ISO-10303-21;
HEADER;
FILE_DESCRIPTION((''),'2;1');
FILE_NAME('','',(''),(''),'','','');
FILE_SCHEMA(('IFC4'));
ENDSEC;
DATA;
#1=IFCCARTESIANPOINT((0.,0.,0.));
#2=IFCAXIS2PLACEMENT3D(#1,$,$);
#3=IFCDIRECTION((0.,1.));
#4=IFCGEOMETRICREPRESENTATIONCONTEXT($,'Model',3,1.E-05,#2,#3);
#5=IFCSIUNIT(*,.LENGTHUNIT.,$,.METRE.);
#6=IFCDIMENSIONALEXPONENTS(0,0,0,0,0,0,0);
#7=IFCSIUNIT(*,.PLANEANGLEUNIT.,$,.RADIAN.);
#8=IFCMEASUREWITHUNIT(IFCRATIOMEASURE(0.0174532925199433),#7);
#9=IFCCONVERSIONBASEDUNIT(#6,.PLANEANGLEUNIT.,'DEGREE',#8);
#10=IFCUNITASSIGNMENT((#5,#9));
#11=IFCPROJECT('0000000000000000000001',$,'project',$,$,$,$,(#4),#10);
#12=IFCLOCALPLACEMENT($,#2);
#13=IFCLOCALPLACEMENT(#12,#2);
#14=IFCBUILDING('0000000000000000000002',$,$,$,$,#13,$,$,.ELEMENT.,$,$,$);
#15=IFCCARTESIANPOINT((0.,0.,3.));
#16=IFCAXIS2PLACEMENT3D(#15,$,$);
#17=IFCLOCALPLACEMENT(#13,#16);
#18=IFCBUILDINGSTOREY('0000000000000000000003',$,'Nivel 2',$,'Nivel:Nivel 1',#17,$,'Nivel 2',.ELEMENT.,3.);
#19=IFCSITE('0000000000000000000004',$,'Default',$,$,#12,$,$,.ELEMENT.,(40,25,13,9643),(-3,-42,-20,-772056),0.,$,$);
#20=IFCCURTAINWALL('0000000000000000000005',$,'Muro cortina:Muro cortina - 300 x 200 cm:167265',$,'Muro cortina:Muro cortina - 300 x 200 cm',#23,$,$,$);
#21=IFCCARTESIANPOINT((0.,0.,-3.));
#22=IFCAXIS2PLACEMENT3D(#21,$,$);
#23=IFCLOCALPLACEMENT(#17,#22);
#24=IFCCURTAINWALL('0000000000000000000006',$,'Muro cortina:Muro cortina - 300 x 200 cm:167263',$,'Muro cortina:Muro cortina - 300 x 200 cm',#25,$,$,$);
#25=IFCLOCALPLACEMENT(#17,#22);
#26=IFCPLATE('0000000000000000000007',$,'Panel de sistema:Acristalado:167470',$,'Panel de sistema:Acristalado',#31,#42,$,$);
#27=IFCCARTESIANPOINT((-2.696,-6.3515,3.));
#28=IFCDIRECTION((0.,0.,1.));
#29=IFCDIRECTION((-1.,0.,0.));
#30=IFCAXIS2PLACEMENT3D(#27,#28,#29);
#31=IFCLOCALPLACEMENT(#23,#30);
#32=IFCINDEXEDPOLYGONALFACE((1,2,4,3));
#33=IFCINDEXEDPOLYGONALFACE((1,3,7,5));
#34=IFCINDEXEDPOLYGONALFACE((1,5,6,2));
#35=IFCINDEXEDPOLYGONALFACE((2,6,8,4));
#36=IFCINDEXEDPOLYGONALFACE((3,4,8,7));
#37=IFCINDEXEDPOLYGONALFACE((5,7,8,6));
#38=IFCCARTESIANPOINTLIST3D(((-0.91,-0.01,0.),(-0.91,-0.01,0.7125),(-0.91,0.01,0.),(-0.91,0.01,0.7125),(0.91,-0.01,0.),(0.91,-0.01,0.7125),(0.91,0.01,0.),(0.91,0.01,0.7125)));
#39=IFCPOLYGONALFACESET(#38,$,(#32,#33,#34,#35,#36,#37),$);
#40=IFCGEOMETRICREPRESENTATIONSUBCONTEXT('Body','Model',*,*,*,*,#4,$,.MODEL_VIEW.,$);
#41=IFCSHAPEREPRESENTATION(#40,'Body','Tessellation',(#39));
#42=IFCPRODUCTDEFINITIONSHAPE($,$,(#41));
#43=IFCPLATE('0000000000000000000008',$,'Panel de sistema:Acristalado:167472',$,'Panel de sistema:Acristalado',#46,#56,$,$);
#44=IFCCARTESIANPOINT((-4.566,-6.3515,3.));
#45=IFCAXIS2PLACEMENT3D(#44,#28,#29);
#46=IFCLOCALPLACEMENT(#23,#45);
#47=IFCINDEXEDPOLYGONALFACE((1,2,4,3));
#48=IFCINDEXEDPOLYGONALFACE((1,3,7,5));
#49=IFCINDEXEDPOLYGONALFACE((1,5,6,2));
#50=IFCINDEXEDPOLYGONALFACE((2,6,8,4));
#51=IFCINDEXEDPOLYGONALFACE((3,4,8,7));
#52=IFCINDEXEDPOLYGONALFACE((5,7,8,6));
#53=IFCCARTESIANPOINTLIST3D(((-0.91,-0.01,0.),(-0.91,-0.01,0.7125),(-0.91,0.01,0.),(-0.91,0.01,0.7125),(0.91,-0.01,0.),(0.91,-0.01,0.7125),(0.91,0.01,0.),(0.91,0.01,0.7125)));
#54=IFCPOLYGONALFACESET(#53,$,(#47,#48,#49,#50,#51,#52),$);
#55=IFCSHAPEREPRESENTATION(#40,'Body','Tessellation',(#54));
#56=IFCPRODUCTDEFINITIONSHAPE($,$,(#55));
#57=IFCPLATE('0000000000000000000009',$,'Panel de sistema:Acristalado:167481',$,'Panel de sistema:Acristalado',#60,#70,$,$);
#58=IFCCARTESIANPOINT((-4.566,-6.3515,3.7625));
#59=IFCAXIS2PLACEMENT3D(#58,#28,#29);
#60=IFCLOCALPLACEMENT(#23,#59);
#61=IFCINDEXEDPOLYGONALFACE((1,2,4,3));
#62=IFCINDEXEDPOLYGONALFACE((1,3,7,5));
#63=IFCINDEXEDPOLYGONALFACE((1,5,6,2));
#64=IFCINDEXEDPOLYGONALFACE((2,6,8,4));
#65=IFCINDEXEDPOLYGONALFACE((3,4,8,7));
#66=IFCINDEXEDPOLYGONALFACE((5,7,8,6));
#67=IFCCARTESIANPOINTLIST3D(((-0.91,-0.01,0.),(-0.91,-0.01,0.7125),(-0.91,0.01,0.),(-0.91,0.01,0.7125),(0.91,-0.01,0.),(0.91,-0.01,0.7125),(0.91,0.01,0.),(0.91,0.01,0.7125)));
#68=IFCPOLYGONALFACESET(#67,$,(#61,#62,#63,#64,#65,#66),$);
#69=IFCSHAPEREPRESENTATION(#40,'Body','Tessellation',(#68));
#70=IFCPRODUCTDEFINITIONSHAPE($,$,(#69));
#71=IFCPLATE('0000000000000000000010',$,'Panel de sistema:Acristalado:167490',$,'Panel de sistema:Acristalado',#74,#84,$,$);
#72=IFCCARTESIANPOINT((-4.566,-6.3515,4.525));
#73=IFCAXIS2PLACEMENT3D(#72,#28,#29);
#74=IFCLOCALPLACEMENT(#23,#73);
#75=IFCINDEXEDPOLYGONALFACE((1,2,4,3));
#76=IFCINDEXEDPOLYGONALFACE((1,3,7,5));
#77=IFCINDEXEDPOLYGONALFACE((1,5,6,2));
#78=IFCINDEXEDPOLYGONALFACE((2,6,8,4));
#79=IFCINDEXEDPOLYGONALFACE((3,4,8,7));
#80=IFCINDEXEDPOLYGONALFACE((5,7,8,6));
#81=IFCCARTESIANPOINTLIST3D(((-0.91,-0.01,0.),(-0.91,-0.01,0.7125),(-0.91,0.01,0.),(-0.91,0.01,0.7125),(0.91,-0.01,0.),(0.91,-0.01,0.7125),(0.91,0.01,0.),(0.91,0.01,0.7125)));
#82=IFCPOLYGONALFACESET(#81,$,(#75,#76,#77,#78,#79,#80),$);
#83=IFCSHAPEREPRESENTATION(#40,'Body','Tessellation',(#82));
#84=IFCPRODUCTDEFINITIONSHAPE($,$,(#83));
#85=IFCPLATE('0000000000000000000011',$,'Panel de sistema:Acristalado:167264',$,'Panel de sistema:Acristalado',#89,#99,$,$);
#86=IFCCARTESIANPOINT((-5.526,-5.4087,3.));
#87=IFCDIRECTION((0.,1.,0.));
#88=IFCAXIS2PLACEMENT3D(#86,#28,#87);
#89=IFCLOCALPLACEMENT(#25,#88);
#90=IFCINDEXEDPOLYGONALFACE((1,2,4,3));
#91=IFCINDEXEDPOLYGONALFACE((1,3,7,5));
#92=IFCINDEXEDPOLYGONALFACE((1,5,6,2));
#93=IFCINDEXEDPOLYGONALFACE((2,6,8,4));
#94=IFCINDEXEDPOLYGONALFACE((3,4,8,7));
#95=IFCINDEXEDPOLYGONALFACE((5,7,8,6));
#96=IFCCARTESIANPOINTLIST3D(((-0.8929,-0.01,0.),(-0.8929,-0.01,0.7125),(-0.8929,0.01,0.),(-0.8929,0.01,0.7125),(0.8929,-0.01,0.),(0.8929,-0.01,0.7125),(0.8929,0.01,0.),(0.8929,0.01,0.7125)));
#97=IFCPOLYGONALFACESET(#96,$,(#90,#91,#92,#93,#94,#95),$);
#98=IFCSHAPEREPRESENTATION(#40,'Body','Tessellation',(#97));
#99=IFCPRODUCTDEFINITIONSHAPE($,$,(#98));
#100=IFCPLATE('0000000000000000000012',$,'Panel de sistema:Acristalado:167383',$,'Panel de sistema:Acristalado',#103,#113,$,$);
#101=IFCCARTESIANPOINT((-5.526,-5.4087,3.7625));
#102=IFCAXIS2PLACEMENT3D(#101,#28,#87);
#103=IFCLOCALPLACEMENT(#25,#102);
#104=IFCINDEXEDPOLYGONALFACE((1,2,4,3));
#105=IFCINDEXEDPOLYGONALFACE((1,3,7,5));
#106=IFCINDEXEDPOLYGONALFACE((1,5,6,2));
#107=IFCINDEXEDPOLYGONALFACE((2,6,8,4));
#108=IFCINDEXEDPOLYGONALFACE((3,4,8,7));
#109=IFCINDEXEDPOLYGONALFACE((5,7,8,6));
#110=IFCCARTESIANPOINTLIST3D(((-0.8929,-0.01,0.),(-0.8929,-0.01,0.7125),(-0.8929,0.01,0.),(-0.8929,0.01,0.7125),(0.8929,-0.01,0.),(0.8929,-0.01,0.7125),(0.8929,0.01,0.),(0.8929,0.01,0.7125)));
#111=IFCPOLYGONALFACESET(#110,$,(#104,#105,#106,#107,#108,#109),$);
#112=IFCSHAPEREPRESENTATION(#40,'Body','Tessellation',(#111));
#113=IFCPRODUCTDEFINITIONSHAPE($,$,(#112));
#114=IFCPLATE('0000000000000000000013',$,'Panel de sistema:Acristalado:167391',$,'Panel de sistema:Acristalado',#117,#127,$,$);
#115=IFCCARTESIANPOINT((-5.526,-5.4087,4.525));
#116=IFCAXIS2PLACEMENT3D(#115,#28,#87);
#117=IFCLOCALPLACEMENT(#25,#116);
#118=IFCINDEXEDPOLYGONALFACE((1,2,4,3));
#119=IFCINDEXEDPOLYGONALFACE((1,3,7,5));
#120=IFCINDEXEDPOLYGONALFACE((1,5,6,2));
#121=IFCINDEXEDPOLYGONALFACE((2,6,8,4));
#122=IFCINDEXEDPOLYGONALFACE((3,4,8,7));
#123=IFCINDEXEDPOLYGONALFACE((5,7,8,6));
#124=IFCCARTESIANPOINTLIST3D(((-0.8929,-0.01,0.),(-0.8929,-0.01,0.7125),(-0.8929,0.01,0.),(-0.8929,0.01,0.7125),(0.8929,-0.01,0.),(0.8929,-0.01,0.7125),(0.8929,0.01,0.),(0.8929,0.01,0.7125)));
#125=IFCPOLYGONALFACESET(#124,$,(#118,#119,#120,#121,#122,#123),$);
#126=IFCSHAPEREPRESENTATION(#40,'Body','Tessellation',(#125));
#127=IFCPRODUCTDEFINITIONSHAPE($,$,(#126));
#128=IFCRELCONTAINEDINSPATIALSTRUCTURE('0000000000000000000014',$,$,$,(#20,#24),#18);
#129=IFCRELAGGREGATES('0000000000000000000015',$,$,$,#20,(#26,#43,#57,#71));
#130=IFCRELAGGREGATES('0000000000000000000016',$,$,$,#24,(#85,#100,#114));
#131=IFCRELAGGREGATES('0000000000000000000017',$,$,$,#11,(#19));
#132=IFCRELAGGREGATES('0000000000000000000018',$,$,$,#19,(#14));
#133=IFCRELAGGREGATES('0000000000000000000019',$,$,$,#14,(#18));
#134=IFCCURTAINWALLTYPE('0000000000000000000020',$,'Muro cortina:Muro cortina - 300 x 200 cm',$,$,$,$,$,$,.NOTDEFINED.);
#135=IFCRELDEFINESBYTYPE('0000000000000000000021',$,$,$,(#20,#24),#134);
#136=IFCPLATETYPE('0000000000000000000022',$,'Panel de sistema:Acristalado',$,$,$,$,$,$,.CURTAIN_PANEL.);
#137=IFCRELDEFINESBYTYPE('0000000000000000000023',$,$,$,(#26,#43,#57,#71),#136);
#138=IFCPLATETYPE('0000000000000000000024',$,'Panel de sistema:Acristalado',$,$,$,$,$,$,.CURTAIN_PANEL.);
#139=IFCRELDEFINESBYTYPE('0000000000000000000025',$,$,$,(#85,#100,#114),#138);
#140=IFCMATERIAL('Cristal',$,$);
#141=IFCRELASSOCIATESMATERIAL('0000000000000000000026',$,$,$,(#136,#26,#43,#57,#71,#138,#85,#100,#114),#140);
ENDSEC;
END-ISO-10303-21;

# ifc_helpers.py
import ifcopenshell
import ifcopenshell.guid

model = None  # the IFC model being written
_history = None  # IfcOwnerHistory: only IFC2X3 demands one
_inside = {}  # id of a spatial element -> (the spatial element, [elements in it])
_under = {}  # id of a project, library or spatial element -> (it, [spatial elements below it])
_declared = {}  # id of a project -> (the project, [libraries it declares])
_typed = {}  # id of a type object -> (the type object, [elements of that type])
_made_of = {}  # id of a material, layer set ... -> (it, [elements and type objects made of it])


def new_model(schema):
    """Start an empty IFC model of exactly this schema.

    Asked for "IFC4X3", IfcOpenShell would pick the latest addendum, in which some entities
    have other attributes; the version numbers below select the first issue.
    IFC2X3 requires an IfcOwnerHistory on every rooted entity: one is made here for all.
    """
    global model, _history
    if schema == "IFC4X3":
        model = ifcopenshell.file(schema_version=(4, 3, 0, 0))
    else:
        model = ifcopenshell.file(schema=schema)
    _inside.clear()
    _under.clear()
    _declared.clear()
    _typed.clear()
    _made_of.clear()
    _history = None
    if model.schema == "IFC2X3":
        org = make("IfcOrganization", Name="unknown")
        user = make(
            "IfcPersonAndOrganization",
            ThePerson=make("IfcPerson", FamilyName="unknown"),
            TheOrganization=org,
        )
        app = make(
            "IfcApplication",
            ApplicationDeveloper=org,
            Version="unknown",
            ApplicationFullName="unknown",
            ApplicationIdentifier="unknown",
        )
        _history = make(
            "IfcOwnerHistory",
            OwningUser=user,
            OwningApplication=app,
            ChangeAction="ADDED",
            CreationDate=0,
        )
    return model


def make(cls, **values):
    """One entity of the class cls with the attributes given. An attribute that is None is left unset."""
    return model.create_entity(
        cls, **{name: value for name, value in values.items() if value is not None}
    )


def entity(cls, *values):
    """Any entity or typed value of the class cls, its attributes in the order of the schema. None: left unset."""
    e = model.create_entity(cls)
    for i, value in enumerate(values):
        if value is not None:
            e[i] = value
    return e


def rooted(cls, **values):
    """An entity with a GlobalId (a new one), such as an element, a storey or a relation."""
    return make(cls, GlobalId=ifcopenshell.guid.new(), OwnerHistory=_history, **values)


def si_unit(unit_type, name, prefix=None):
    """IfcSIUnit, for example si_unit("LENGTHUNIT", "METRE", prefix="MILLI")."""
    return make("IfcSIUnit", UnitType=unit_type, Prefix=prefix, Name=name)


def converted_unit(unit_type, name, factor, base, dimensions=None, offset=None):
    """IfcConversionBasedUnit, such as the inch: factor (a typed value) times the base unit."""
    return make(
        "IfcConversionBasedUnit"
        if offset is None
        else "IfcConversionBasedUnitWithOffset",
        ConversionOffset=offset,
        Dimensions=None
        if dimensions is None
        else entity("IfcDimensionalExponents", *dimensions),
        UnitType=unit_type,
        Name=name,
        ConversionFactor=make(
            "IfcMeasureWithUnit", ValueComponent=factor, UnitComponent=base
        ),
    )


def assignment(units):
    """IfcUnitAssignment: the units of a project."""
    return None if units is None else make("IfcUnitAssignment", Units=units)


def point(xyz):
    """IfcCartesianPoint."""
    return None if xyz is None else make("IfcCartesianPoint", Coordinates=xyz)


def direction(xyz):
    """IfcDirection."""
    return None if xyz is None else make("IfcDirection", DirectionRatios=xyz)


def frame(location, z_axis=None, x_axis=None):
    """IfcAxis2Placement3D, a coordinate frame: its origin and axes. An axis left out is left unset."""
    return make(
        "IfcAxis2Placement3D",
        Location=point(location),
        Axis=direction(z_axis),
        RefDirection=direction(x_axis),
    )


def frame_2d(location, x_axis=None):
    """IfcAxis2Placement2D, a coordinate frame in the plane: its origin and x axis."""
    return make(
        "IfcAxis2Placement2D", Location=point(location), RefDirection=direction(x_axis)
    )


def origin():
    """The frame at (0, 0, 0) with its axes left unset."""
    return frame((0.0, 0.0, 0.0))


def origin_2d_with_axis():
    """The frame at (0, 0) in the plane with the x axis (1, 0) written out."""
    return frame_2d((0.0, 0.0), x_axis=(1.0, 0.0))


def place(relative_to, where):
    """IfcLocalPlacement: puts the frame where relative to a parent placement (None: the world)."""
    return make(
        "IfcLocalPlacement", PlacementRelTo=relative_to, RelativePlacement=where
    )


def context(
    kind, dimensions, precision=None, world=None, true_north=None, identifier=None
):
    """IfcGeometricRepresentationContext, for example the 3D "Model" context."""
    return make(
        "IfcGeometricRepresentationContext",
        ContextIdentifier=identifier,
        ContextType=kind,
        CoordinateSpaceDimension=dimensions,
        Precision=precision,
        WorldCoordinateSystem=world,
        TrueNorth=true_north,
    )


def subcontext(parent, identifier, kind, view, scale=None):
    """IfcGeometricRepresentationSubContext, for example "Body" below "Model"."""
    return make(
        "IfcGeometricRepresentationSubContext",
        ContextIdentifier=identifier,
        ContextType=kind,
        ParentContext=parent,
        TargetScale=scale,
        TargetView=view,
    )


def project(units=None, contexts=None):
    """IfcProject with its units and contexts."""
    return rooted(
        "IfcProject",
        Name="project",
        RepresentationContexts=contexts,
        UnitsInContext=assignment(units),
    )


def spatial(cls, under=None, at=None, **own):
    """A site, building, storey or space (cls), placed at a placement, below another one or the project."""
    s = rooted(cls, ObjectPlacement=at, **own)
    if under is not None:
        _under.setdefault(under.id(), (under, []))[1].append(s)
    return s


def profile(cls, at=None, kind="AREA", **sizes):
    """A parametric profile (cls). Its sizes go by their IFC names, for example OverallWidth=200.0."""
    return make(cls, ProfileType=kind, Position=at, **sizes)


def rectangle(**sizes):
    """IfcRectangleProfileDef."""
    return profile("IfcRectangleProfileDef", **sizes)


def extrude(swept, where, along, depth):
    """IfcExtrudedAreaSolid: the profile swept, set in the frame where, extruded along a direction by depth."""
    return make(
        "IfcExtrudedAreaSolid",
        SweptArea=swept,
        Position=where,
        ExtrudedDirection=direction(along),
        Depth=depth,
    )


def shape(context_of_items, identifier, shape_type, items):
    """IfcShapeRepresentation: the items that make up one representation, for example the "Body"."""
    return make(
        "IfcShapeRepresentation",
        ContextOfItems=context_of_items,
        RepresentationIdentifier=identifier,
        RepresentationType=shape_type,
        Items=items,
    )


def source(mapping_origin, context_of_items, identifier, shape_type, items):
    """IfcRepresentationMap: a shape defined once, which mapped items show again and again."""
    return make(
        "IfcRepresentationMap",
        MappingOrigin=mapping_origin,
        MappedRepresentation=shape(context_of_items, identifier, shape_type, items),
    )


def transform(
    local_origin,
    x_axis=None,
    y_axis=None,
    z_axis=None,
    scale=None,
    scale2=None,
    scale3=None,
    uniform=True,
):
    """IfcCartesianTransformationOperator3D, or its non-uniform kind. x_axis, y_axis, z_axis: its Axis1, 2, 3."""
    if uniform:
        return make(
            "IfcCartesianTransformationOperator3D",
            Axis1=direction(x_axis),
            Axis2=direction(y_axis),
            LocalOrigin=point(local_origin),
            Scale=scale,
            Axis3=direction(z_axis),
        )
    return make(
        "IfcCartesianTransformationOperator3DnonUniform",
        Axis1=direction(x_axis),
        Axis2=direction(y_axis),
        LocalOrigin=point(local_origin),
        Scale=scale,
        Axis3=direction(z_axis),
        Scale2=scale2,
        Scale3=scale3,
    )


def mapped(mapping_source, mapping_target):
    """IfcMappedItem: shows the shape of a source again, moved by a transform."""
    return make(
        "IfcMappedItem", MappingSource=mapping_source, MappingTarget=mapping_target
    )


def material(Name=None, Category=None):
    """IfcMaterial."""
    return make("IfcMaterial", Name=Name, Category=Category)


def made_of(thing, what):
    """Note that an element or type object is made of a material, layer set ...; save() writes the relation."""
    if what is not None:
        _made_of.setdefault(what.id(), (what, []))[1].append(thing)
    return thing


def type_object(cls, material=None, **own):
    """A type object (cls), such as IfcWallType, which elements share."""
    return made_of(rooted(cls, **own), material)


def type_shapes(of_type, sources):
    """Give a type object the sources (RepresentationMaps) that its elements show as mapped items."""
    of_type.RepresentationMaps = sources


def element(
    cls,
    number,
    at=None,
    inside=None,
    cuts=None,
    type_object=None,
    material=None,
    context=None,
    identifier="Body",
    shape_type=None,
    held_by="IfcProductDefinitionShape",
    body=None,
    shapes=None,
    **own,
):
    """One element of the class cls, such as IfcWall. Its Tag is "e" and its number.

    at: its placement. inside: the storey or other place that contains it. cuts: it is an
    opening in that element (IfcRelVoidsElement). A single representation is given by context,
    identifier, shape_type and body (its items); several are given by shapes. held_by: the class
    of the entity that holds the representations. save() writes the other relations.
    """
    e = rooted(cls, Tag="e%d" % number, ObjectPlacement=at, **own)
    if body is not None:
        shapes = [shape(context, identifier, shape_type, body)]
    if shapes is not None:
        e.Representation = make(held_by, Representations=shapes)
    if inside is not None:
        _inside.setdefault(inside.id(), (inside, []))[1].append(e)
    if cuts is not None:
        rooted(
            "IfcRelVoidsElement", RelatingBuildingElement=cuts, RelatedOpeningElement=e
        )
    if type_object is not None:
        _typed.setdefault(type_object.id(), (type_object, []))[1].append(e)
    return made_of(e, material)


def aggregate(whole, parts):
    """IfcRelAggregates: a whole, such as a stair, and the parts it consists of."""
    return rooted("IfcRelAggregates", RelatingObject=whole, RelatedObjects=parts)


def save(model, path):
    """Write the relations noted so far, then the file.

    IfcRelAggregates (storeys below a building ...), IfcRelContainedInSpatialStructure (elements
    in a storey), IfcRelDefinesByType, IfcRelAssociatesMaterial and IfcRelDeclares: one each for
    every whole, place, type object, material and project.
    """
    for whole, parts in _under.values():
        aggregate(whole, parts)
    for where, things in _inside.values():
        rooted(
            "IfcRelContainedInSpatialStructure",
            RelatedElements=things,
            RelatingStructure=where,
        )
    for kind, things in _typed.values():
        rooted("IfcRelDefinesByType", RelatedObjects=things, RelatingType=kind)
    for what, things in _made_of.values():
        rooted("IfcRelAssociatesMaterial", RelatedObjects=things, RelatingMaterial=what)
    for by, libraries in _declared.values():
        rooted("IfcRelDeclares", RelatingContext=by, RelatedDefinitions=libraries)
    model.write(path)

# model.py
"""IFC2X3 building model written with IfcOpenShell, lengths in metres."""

from ifc_helpers import new_model, entity, si_unit, converted_unit, direction, frame, origin, origin_2d_with_axis, place, context, subcontext, project, spatial, rectangle, extrude, source, transform, mapped, material, type_object, type_shapes, element, aggregate, save


model = new_model("IFC2X3")

# Units and contexts
model_context = context("Model", 3, precision=1e-05, world=origin(), true_north=direction((0.0, 1.0)))
body_context = subcontext(model_context, "Body", "Model", "MODEL_VIEW")
ifc_project = project(units=[si_unit("LENGTHUNIT", "METRE"), converted_unit("PLANEANGLEUNIT", "DEGREE", entity("IfcRatioMeasure", 0.0174532925199433), si_unit("PLANEANGLEUNIT", "RADIAN"), dimensions=[0, 0, 0, 0, 0, 0, 0])], contexts=[model_context])

# Site, building, storey
site_placement = place(None, origin())
site = spatial("IfcSite", under=ifc_project, at=site_placement, Name="Default", CompositionType="ELEMENT", RefLatitude=(40, 25, 13, 9643), RefLongitude=(-3, -42, -20, -772056), RefElevation=0.0)
building_placement = place(site_placement, origin())
building = spatial("IfcBuilding", under=site, at=building_placement, CompositionType="ELEMENT")
storey_placement = place(building_placement, frame((0.0, 0.0, 3.0)))
storey = spatial("IfcBuildingStorey", under=building, at=storey_placement, Name="Nivel 2", ObjectType="Nivel:Nivel 1", LongName="Nivel 2", CompositionType="ELEMENT", Elevation=3.0)

# Curtain walls
curtain_wall_type = type_object("IfcCurtainWallType", Name="Muro cortina:Muro cortina - 300 x 200 cm", PredefinedType="NOTDEFINED")
curtain_wall_1_placement = place(storey_placement, frame((0.0, 0.0, -3.0)))
curtain_wall_1 = element("IfcCurtainWall", 1, at=curtain_wall_1_placement, inside=storey, type_object=curtain_wall_type, Name="Muro cortina:Muro cortina - 300 x 200 cm:167265", ObjectType="Muro cortina:Muro cortina - 300 x 200 cm")
curtain_wall_2_placement = place(storey_placement, frame((0.0, 0.0, -3.0)))
curtain_wall_2 = element("IfcCurtainWall", 2, at=curtain_wall_2_placement, inside=storey, type_object=curtain_wall_type, Name="Muro cortina:Muro cortina - 300 x 200 cm:167263", ObjectType="Muro cortina:Muro cortina - 300 x 200 cm")

# Plates
ifc_material_1 = material(Name="Cristal")
plate_type_1 = type_object("IfcPlateType", Name="Panel de sistema:Acristalado", PredefinedType="CURTAIN_PANEL", material=ifc_material_1)
shared_shape_1 = source(origin(), body_context, "Body", "SweptSolid", [
    extrude(rectangle(XDim=0.02, YDim=1.82, at=origin_2d_with_axis()), frame((0.0, 0.0, 0.0), z_axis=(0.0, 0.0, 1.0), x_axis=(0.0, 1.0, 0.0)), (0.0, 0.0, 1.0), 0.7125),
])
type_shapes(plate_type_1, [shared_shape_1])
plate_1_placement = place(curtain_wall_1_placement, frame((-2.696, -6.3515, 3.0), z_axis=(0.0, 0.0, 1.0), x_axis=(-1.0, 0.0, 0.0)))
plate_1 = element("IfcPlate", 3, at=plate_1_placement, type_object=plate_type_1, material=ifc_material_1, Name="Panel de sistema:Acristalado:167470", ObjectType="Panel de sistema:Acristalado", context=body_context, shape_type="MappedRepresentation", body=[
    mapped(shared_shape_1, transform((0.0, 0.0, 0.0), scale=1.0)),
])
plate_2_placement = place(curtain_wall_1_placement, frame((-4.566, -6.3515, 3.0), z_axis=(0.0, 0.0, 1.0), x_axis=(-1.0, 0.0, 0.0)))
plate_2 = element("IfcPlate", 4, at=plate_2_placement, type_object=plate_type_1, material=ifc_material_1, Name="Panel de sistema:Acristalado:167472", ObjectType="Panel de sistema:Acristalado", context=body_context, shape_type="MappedRepresentation", body=[
    mapped(shared_shape_1, transform((0.0, 0.0, 0.0), scale=1.0)),
])
plate_3_placement = place(curtain_wall_1_placement, frame((-4.566, -6.3515, 3.7625), z_axis=(0.0, 0.0, 1.0), x_axis=(-1.0, 0.0, 0.0)))
plate_3 = element("IfcPlate", 5, at=plate_3_placement, type_object=plate_type_1, material=ifc_material_1, Name="Panel de sistema:Acristalado:167481", ObjectType="Panel de sistema:Acristalado", context=body_context, shape_type="MappedRepresentation", body=[
    mapped(shared_shape_1, transform((0.0, 0.0, 0.0), scale=1.0)),
])
plate_4_placement = place(curtain_wall_1_placement, frame((-4.566, -6.3515, 4.525), z_axis=(0.0, 0.0, 1.0), x_axis=(-1.0, 0.0, 0.0)))
plate_4 = element("IfcPlate", 6, at=plate_4_placement, type_object=plate_type_1, material=ifc_material_1, Name="Panel de sistema:Acristalado:167490", ObjectType="Panel de sistema:Acristalado", context=body_context, shape_type="MappedRepresentation", body=[
    mapped(shared_shape_1, transform((0.0, 0.0, 0.0), scale=1.0)),
])
aggregate(curtain_wall_1, [plate_1, plate_2, plate_3, plate_4])
plate_type_2 = type_object("IfcPlateType", Name="Panel de sistema:Acristalado", PredefinedType="CURTAIN_PANEL", material=ifc_material_1)
shared_shape_2 = source(origin(), body_context, "Body", "SweptSolid", [
    extrude(rectangle(XDim=0.02, YDim=1.7857, at=origin_2d_with_axis()), frame((0.0, 0.0, 0.0), z_axis=(0.0, 0.0, 1.0), x_axis=(0.0, 1.0, 0.0)), (0.0, 0.0, 1.0), 0.7125),
])
type_shapes(plate_type_2, [shared_shape_2])
plate_5_placement = place(curtain_wall_2_placement, frame((-5.526, -5.4087, 3.0), z_axis=(0.0, 0.0, 1.0), x_axis=(0.0, 1.0, 0.0)))
plate_5 = element("IfcPlate", 7, at=plate_5_placement, type_object=plate_type_2, material=ifc_material_1, Name="Panel de sistema:Acristalado:167264", ObjectType="Panel de sistema:Acristalado", context=body_context, shape_type="MappedRepresentation", body=[
    mapped(shared_shape_2, transform((0.0, 0.0, 0.0), scale=1.0)),
])
plate_6_placement = place(curtain_wall_2_placement, frame((-5.526, -5.4087, 3.7625), z_axis=(0.0, 0.0, 1.0), x_axis=(0.0, 1.0, 0.0)))
plate_6 = element("IfcPlate", 8, at=plate_6_placement, type_object=plate_type_2, material=ifc_material_1, Name="Panel de sistema:Acristalado:167383", ObjectType="Panel de sistema:Acristalado", context=body_context, shape_type="MappedRepresentation", body=[
    mapped(shared_shape_2, transform((0.0, 0.0, 0.0), scale=1.0)),
])
plate_7_placement = place(curtain_wall_2_placement, frame((-5.526, -5.4087, 4.525), z_axis=(0.0, 0.0, 1.0), x_axis=(0.0, 1.0, 0.0)))
plate_7 = element("IfcPlate", 9, at=plate_7_placement, type_object=plate_type_2, material=ifc_material_1, Name="Panel de sistema:Acristalado:167391", ObjectType="Panel de sistema:Acristalado", context=body_context, shape_type="MappedRepresentation", body=[
    mapped(shared_shape_2, transform((0.0, 0.0, 0.0), scale=1.0)),
])
aggregate(curtain_wall_2, [plate_5, plate_6, plate_7])

save(model, "model.ifc")
